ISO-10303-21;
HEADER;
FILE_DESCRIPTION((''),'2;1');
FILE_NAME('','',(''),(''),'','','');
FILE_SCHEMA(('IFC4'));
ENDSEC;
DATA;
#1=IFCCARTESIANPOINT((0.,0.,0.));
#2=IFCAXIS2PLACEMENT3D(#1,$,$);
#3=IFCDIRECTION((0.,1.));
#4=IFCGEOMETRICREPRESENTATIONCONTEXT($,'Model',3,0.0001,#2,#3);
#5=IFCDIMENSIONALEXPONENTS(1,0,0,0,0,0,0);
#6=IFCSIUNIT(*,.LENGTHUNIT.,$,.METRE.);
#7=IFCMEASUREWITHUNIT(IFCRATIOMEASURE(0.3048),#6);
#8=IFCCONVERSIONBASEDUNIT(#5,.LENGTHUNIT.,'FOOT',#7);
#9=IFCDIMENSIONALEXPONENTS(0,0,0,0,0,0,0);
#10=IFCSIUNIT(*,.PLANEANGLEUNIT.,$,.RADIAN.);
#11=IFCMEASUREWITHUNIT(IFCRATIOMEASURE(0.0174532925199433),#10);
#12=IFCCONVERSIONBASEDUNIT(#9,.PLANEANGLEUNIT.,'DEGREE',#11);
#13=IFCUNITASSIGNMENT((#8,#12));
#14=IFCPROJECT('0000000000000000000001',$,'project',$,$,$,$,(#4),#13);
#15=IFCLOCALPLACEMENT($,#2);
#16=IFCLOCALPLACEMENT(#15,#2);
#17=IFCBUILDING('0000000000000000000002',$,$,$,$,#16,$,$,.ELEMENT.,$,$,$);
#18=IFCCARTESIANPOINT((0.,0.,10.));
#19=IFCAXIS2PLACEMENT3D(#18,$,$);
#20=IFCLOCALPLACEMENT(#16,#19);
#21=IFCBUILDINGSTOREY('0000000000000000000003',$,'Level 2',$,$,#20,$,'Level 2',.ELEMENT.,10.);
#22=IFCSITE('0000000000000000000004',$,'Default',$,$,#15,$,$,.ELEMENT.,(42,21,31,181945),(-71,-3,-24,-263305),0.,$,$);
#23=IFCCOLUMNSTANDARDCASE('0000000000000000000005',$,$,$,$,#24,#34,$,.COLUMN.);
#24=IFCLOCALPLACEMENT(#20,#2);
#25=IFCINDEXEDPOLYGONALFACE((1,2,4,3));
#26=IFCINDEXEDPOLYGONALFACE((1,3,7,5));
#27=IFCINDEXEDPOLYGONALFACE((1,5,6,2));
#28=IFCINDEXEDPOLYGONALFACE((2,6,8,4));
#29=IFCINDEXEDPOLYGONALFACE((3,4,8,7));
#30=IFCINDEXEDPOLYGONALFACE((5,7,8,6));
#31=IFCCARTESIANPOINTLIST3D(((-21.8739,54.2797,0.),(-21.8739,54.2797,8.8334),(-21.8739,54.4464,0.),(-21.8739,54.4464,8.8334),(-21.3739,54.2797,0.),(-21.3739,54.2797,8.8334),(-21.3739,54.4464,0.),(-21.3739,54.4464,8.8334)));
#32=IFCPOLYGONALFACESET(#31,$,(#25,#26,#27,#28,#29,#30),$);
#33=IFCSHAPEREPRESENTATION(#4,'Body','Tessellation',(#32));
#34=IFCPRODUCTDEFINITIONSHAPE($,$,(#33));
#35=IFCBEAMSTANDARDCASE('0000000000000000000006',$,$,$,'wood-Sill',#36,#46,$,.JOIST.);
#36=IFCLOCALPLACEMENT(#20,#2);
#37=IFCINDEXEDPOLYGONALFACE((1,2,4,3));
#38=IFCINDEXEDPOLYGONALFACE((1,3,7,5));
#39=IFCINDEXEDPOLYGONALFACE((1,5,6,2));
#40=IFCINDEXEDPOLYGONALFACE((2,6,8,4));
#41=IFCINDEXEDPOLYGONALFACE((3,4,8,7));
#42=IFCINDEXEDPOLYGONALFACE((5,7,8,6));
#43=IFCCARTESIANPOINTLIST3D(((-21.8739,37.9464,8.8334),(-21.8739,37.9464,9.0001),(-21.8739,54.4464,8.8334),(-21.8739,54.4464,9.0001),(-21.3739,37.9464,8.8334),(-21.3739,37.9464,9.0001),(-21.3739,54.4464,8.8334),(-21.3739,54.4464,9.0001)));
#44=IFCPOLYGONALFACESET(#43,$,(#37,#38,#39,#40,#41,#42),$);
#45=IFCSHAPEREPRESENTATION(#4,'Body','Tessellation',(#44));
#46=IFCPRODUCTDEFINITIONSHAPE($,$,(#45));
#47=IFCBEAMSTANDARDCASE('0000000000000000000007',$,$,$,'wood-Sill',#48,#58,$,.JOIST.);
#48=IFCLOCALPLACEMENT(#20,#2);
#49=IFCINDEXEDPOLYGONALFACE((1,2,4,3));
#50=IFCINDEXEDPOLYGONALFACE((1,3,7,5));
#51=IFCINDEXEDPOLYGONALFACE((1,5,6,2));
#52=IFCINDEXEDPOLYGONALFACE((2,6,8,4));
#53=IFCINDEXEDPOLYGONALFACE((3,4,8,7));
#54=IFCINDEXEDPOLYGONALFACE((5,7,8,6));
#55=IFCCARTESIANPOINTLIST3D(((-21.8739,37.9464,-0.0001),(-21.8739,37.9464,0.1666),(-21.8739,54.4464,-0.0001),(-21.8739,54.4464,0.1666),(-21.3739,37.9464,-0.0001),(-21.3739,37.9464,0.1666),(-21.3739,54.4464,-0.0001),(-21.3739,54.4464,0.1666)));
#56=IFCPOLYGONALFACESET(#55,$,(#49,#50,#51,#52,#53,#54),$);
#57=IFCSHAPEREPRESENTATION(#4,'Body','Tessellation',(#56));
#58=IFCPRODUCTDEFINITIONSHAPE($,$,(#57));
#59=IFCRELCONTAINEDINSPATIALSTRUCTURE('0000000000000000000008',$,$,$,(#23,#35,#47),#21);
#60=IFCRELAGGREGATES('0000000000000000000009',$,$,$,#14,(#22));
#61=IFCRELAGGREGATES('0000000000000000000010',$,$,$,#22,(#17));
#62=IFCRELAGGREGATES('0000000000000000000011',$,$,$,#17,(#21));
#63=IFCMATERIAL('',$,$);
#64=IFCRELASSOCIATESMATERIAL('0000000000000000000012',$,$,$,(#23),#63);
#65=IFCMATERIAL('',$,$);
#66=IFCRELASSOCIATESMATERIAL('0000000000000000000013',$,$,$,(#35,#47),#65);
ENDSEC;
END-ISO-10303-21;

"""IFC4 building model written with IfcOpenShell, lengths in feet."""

from ifc_helpers import new_model, entity, si_unit, converted_unit, direction, frame, origin, origin_with_axes, place, context, project, spatial, rectangle, extrude, material, element, save


model = new_model("IFC4")

# Units and contexts
model_context = context("Model", 3, precision=0.0001, world=origin(), true_north=direction((0.0, 1.0)))
ifc_project = project(units=[converted_unit("LENGTHUNIT", "FOOT", entity("IfcRatioMeasure", 0.3048), si_unit("LENGTHUNIT", "METRE"), dimensions=[1, 0, 0, 0, 0, 0, 0]), converted_unit("PLANEANGLEUNIT", "DEGREE", entity("IfcRatioMeasure", 0.0174532925199433), si_unit("PLANEANGLEUNIT", "RADIAN"), dimensions=[0, 0, 0, 0, 0, 0, 0])], contexts=[model_context])

# Site, building, storey
site_placement = place(None, origin())
site = spatial("IfcSite", under=ifc_project, at=site_placement, Name="Default", CompositionType="ELEMENT", RefLatitude=(42, 21, 31, 181945), RefLongitude=(-71, -3, -24, -263305), RefElevation=0.0)
building_placement = place(site_placement, origin())
building = spatial("IfcBuilding", under=site, at=building_placement, CompositionType="ELEMENT")
storey_placement = place(building_placement, frame((0.0, 0.0, 10.0)))
storey = spatial("IfcBuildingStorey", under=building, at=storey_placement, Name="Level 2", LongName="Level 2", CompositionType="ELEMENT", Elevation=10.0)

# Column
ifc_material_1 = material(Name="")
placement_1 = place(storey_placement, frame((-21.6239, 54.4464, 0.0), z_axis=(0.0, 0.0, 1.0), x_axis=(0.0, -1.0, 0.0)))
for number, where, z_axis, x_axis in (
    (1, (0.0833, 0.0, 0.0), (0.0, 0.0, 1.0), (1.0, 0.0, 0.0)),
):
    element("IfcColumnStandardCase", number, at=place(placement_1, frame(where, z_axis=z_axis, x_axis=x_axis)), inside=storey, material=ifc_material_1, PredefinedType="COLUMN", context=model_context, shape_type="SweptSolid", body=[
        extrude(rectangle(XDim=0.1667, YDim=0.5), origin(), (0.0, 0.0, 1.0), 8.8334),
    ])

# Beams
ifc_material_2 = material(Name="")
for number, where, z_axis, x_axis in (
    (2, (0.0, 0.0, 8.9167), (1.0, 0.0, 0.0), (0.0, 0.0, 1.0)),
    (3, (0.0, 0.0, 0.0833), (1.0, 0.0, 0.0), (0.0, 0.0, 1.0)),
):
    element("IfcBeamStandardCase", number, at=place(placement_1, frame(where, z_axis=z_axis, x_axis=x_axis)), inside=storey, material=ifc_material_2, ObjectType="wood-Sill", PredefinedType="JOIST", context=model_context, shape_type="SweptSolid", body=[
        extrude(rectangle(XDim=0.1667, YDim=0.5), origin_with_axes(), (0.0, 0.0, 1.0), 16.5),
    ])

save(model, "model.ifc")
